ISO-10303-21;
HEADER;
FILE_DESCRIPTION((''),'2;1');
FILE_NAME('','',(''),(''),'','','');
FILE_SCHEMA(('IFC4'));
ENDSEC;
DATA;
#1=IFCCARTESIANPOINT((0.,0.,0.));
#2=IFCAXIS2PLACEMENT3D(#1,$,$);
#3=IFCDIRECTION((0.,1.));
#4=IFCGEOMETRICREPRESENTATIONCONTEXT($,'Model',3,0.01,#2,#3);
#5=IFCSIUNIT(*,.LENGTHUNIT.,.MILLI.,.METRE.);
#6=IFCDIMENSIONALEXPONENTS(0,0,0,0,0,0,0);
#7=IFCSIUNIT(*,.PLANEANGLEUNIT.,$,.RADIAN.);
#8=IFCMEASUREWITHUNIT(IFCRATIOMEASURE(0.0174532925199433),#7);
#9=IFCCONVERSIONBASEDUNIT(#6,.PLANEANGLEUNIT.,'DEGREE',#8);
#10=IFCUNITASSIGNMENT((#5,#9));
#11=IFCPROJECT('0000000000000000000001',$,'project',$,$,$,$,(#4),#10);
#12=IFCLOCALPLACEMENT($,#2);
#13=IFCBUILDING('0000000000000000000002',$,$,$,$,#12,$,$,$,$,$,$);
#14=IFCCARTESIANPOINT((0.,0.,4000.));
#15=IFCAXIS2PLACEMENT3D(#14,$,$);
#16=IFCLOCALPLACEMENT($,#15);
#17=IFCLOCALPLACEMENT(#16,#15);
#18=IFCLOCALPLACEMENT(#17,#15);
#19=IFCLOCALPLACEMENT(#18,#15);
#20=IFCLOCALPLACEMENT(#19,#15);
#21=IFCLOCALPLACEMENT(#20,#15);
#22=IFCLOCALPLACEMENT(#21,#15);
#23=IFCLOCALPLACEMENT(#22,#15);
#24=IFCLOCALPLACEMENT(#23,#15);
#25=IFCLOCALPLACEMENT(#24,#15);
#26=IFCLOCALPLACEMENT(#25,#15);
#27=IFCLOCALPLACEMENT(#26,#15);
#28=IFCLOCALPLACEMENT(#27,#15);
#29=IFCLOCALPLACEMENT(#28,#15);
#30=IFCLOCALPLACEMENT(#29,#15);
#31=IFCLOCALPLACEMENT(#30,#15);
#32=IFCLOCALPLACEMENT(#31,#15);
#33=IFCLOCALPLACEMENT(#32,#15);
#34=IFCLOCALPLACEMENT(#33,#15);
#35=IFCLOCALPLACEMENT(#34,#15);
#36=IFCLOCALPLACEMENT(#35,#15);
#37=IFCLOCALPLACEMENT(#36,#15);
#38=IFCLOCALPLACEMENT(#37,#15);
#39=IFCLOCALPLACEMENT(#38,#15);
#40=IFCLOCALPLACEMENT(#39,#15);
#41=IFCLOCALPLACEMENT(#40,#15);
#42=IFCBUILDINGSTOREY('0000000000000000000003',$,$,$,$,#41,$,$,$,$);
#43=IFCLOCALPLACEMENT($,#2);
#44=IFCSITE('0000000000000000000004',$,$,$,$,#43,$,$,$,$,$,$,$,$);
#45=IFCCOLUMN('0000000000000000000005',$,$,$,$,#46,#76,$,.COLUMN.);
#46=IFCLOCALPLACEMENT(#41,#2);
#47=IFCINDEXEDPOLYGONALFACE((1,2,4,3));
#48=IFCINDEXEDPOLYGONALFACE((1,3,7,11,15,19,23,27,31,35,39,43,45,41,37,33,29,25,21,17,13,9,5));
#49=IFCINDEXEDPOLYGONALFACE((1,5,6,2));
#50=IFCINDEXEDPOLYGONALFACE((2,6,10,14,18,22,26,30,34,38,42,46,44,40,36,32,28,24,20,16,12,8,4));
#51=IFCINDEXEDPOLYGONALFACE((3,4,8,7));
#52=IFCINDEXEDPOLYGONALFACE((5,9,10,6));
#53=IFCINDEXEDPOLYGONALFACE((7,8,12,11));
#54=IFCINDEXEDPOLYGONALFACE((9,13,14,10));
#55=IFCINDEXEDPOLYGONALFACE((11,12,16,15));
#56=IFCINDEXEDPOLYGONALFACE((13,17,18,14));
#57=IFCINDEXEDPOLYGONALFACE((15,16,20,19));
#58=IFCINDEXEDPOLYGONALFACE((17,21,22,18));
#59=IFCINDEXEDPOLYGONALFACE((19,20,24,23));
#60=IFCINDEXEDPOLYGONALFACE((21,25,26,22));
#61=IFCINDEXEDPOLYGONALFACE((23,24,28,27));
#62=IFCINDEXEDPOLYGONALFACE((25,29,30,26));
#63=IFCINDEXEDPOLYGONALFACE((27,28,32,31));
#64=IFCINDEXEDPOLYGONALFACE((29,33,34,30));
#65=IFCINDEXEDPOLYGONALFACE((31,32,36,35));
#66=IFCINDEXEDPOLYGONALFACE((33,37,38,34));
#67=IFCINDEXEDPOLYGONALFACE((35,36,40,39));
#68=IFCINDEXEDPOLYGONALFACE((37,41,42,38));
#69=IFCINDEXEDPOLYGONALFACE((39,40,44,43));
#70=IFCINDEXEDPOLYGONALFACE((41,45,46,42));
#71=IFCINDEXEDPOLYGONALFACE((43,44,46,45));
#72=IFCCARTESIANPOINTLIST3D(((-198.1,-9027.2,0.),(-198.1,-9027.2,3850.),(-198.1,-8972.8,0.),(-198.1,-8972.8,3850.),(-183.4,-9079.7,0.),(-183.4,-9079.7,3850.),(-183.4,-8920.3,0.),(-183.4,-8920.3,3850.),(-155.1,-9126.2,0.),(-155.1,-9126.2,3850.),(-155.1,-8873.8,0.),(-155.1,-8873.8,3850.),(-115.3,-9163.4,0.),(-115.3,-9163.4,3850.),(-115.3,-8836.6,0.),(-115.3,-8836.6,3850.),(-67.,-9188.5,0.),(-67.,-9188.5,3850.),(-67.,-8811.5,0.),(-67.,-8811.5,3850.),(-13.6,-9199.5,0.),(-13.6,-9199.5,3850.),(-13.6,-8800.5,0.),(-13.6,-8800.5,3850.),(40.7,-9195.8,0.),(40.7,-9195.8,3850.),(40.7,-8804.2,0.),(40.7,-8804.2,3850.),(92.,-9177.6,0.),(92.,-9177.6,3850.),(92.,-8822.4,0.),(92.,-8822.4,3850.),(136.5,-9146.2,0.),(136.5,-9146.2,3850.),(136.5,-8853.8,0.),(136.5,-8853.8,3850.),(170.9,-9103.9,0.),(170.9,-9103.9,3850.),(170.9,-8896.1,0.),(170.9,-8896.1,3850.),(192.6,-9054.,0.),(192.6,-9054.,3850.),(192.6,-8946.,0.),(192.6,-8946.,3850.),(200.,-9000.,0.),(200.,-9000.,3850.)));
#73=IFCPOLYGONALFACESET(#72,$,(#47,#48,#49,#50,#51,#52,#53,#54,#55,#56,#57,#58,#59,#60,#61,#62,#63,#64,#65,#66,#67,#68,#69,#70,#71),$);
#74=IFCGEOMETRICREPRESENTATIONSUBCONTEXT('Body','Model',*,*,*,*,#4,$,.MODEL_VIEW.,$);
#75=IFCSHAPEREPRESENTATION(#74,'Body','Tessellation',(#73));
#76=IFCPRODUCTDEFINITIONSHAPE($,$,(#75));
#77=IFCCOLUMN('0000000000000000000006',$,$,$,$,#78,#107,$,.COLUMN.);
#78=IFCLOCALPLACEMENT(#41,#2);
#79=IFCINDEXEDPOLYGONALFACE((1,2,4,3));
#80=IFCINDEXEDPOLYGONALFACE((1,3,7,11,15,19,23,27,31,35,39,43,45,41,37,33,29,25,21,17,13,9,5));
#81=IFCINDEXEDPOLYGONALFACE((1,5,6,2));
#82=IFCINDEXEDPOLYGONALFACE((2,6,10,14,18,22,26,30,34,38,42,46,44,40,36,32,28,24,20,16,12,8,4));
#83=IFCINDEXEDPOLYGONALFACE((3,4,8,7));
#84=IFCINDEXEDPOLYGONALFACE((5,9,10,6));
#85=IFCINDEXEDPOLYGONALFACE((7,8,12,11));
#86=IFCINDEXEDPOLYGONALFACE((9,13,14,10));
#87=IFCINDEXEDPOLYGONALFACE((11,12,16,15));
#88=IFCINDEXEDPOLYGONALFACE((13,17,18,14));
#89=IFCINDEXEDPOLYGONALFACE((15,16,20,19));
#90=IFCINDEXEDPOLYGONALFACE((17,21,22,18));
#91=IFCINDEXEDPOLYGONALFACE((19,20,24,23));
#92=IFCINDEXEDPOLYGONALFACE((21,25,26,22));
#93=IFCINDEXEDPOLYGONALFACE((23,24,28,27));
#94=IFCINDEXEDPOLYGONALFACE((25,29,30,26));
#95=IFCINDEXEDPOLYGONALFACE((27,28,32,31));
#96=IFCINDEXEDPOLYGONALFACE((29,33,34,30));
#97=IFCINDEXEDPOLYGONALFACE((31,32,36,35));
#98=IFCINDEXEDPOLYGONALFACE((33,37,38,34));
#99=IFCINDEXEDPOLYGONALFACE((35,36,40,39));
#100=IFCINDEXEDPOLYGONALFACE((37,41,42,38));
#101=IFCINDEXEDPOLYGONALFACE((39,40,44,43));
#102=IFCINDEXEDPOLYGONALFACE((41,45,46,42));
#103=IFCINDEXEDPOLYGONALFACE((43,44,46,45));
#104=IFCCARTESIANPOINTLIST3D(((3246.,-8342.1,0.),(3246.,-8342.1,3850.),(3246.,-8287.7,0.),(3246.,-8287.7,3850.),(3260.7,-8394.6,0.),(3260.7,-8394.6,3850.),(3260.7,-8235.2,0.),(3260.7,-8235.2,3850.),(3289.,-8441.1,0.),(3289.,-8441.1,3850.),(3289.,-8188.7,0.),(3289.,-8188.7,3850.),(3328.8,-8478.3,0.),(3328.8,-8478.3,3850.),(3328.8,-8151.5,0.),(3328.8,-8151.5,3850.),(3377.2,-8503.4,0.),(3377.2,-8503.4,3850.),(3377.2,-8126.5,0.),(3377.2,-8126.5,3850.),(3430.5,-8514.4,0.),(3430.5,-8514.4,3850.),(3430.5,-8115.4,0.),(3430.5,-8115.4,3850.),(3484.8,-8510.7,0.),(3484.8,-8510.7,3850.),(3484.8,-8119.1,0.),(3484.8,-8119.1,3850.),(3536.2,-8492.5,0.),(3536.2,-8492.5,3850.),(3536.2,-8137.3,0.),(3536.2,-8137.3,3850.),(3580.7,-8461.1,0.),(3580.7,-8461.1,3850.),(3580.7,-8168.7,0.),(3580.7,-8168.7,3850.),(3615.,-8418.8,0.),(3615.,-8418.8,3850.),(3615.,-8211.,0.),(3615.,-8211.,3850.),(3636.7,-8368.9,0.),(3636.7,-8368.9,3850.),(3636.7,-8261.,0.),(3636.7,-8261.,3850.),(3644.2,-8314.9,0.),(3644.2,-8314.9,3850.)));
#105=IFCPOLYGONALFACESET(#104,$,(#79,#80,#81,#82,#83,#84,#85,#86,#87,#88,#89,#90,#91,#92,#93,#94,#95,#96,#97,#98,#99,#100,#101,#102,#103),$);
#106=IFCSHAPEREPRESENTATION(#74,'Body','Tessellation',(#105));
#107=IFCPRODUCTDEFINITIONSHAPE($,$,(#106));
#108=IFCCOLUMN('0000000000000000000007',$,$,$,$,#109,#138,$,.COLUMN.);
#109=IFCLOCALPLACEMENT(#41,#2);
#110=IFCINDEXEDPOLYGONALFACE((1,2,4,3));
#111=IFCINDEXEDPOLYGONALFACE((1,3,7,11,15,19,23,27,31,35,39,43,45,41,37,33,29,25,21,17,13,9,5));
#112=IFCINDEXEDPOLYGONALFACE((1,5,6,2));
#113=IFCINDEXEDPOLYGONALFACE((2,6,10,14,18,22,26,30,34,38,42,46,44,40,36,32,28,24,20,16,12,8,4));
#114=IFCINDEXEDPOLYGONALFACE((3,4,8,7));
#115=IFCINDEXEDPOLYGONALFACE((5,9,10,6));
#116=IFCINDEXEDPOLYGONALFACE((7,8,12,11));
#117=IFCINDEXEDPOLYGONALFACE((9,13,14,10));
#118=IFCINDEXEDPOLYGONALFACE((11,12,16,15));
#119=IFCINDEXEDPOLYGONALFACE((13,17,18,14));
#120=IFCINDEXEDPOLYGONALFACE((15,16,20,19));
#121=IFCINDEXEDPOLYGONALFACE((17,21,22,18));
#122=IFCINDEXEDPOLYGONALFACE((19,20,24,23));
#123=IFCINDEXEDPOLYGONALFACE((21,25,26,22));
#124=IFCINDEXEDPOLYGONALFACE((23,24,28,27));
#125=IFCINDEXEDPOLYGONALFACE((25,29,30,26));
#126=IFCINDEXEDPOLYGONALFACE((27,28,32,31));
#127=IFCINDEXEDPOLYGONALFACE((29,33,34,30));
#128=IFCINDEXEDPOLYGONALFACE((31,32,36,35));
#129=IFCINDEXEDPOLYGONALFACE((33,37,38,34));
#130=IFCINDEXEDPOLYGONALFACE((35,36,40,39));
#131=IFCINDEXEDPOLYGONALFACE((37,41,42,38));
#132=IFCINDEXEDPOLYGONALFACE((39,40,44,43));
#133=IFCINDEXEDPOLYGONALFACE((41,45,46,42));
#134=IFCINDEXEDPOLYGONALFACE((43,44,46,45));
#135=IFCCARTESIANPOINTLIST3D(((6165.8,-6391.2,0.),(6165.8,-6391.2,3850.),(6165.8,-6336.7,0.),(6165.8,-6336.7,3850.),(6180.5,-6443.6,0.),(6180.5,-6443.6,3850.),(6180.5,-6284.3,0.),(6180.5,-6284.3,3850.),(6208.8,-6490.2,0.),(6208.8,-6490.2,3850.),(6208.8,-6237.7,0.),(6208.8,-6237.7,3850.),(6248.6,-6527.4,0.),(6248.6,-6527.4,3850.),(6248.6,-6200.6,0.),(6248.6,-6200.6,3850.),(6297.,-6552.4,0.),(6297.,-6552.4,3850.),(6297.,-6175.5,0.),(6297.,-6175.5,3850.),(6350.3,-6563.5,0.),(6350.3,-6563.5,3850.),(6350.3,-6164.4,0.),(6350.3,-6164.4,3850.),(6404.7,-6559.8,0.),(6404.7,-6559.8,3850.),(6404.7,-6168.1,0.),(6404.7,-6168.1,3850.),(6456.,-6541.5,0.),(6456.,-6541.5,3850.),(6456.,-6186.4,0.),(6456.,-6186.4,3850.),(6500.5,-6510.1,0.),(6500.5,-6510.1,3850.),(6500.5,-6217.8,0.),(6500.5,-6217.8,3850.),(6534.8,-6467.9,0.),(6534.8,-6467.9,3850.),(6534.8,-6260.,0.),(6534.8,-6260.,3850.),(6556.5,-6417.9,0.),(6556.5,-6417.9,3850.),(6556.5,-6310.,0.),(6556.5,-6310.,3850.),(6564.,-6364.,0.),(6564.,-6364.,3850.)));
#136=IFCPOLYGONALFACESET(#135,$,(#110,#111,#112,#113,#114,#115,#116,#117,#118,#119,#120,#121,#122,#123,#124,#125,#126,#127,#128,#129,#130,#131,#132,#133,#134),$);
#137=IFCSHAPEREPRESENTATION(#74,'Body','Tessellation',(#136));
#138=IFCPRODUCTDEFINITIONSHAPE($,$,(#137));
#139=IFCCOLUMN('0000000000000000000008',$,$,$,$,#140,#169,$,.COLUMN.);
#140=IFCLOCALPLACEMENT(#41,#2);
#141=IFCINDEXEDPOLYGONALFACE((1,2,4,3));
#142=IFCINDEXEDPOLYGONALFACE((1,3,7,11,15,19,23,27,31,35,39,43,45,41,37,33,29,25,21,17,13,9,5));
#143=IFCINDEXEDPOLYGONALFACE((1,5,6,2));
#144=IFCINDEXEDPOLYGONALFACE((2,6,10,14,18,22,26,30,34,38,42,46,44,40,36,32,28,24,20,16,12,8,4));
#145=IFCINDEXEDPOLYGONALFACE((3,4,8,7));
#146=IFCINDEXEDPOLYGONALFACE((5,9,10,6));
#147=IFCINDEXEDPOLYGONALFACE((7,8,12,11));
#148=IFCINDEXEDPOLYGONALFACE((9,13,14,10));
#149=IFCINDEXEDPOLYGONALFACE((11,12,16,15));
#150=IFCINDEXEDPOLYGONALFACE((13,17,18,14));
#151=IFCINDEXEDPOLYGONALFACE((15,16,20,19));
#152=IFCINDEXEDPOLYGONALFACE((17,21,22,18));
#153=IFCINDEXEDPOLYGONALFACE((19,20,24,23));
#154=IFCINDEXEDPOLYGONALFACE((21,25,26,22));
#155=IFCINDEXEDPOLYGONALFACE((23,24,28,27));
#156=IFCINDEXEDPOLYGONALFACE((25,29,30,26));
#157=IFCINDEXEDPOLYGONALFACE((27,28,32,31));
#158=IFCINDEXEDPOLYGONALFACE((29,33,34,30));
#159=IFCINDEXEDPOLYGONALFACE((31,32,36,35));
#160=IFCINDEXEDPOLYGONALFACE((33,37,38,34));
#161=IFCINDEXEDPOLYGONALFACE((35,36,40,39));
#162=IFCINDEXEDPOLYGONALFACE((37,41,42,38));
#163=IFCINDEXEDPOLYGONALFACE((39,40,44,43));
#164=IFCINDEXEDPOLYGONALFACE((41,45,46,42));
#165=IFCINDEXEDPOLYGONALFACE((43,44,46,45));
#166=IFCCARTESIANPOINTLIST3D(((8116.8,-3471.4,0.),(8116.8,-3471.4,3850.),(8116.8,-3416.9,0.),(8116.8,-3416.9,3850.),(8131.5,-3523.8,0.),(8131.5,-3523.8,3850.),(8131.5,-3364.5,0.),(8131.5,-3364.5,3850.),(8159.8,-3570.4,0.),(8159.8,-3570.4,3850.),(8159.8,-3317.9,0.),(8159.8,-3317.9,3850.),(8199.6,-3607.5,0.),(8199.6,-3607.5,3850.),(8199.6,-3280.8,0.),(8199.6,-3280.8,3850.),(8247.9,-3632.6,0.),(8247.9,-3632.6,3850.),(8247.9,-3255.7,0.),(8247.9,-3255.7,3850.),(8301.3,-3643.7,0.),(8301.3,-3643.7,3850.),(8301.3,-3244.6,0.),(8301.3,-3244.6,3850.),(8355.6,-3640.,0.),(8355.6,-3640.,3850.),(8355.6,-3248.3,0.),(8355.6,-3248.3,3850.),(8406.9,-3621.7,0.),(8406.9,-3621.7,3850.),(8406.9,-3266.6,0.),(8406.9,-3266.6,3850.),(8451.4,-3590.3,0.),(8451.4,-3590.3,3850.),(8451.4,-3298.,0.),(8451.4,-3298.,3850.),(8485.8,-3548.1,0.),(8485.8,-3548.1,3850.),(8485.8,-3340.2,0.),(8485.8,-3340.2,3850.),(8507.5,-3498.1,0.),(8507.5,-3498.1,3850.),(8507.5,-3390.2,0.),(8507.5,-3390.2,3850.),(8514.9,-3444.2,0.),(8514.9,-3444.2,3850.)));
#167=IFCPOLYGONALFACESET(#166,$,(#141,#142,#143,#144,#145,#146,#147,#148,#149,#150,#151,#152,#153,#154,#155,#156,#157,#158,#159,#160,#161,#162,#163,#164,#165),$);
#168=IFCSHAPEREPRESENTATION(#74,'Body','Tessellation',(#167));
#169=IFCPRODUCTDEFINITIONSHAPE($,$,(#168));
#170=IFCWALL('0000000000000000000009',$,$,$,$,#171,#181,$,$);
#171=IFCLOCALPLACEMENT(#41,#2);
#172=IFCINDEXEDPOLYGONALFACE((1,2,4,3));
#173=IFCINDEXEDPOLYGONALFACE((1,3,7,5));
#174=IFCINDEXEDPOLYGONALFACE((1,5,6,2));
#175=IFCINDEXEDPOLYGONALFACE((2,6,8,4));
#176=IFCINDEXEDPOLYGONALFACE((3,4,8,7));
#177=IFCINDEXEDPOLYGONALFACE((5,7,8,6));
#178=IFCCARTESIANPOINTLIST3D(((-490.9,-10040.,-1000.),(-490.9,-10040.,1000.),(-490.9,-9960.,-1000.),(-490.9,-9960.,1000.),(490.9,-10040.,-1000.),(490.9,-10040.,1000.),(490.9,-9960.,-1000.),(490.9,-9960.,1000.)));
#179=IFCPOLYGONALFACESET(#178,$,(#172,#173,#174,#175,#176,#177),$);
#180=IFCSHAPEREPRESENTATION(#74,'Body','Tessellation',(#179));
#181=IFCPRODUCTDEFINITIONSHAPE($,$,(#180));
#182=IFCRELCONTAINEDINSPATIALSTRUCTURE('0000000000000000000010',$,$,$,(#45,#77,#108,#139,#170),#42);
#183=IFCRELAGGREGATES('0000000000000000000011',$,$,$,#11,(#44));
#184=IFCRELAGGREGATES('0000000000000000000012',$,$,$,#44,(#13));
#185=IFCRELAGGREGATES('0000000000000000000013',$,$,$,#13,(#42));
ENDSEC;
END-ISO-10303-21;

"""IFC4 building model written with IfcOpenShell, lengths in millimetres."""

from ifc_helpers import new_model, entity, si_unit, converted_unit, direction, frame, origin, origin_2d, place, context, subcontext, project, spatial, rectangle, circle, extrude, element, save


model = new_model("IFC4")

# Units and contexts
model_context = context("Model", 3, precision=0.01, world=origin(), true_north=direction((0.0, 1.0)))
body_context = subcontext(model_context, "Body", "Model", "MODEL_VIEW")
ifc_project = project(units=[si_unit("LENGTHUNIT", "METRE", prefix="MILLI"), converted_unit("PLANEANGLEUNIT", "DEGREE", entity("IfcRatioMeasure", 0.0174532925199433), si_unit("PLANEANGLEUNIT", "RADIAN"), dimensions=[0, 0, 0, 0, 0, 0, 0])], contexts=[model_context])

# Site, building, storey
site_placement = place(None, origin())
site = spatial("IfcSite", under=ifc_project, at=site_placement)
building_placement = place(None, origin())
building = spatial("IfcBuilding", under=site, at=building_placement)
placement_1 = place(None, frame((0.0, 0.0, 4000.0)))
placement_2 = place(placement_1, frame((0.0, 0.0, 4000.0)))
placement_3 = place(placement_2, frame((0.0, 0.0, 4000.0)))
placement_4 = place(placement_3, frame((0.0, 0.0, 4000.0)))
placement_5 = place(placement_4, frame((0.0, 0.0, 4000.0)))
placement_6 = place(placement_5, frame((0.0, 0.0, 4000.0)))
placement_7 = place(placement_6, frame((0.0, 0.0, 4000.0)))
placement_8 = place(placement_7, frame((0.0, 0.0, 4000.0)))
placement_9 = place(placement_8, frame((0.0, 0.0, 4000.0)))
placement_10 = place(placement_9, frame((0.0, 0.0, 4000.0)))
placement_11 = place(placement_10, frame((0.0, 0.0, 4000.0)))
placement_12 = place(placement_11, frame((0.0, 0.0, 4000.0)))
placement_13 = place(placement_12, frame((0.0, 0.0, 4000.0)))
placement_14 = place(placement_13, frame((0.0, 0.0, 4000.0)))
placement_15 = place(placement_14, frame((0.0, 0.0, 4000.0)))
placement_16 = place(placement_15, frame((0.0, 0.0, 4000.0)))
placement_17 = place(placement_16, frame((0.0, 0.0, 4000.0)))
placement_18 = place(placement_17, frame((0.0, 0.0, 4000.0)))
placement_19 = place(placement_18, frame((0.0, 0.0, 4000.0)))
placement_20 = place(placement_19, frame((0.0, 0.0, 4000.0)))
placement_21 = place(placement_20, frame((0.0, 0.0, 4000.0)))
placement_22 = place(placement_21, frame((0.0, 0.0, 4000.0)))
placement_23 = place(placement_22, frame((0.0, 0.0, 4000.0)))
placement_24 = place(placement_23, frame((0.0, 0.0, 4000.0)))
placement_25 = place(placement_24, frame((0.0, 0.0, 4000.0)))
storey_placement = place(placement_25, frame((0.0, 0.0, 4000.0)))
storey = spatial("IfcBuildingStorey", under=building, at=storey_placement)

# Columns
for number, where in (
    (1, (0.0, -9000.0, 0.0)),
    (2, (3444.2, -8314.9, 0.0)),
    (3, (6364.0, -6364.0, 0.0)),
    (4, (8314.9, -3444.2, 0.0)),
):
    element("IfcColumn", number, at=place(storey_placement, frame(where)), inside=storey, PredefinedType="COLUMN", context=body_context, shape_type="SweptSolid", body=[
        extrude(circle(Radius=200.0, at=origin_2d()), origin(), (0.0, 0.0, 1.0), 3850.0),
    ])

# Wall
wall_1_placement = place(storey_placement, frame((0.0, -10000.0, -1000.0), z_axis=(0.0, 0.0, 1.0), x_axis=(10000.0, 0.000119, 0.0)))
element("IfcWall", 5, at=wall_1_placement, inside=storey, context=body_context, shape_type="SweptSolid", body=[
    extrude(rectangle(XDim=981.7, YDim=80.0, at=origin_2d()), origin(), (0.0, 0.0, 1.0), 2000.0),
])

save(model, "model.ifc")
